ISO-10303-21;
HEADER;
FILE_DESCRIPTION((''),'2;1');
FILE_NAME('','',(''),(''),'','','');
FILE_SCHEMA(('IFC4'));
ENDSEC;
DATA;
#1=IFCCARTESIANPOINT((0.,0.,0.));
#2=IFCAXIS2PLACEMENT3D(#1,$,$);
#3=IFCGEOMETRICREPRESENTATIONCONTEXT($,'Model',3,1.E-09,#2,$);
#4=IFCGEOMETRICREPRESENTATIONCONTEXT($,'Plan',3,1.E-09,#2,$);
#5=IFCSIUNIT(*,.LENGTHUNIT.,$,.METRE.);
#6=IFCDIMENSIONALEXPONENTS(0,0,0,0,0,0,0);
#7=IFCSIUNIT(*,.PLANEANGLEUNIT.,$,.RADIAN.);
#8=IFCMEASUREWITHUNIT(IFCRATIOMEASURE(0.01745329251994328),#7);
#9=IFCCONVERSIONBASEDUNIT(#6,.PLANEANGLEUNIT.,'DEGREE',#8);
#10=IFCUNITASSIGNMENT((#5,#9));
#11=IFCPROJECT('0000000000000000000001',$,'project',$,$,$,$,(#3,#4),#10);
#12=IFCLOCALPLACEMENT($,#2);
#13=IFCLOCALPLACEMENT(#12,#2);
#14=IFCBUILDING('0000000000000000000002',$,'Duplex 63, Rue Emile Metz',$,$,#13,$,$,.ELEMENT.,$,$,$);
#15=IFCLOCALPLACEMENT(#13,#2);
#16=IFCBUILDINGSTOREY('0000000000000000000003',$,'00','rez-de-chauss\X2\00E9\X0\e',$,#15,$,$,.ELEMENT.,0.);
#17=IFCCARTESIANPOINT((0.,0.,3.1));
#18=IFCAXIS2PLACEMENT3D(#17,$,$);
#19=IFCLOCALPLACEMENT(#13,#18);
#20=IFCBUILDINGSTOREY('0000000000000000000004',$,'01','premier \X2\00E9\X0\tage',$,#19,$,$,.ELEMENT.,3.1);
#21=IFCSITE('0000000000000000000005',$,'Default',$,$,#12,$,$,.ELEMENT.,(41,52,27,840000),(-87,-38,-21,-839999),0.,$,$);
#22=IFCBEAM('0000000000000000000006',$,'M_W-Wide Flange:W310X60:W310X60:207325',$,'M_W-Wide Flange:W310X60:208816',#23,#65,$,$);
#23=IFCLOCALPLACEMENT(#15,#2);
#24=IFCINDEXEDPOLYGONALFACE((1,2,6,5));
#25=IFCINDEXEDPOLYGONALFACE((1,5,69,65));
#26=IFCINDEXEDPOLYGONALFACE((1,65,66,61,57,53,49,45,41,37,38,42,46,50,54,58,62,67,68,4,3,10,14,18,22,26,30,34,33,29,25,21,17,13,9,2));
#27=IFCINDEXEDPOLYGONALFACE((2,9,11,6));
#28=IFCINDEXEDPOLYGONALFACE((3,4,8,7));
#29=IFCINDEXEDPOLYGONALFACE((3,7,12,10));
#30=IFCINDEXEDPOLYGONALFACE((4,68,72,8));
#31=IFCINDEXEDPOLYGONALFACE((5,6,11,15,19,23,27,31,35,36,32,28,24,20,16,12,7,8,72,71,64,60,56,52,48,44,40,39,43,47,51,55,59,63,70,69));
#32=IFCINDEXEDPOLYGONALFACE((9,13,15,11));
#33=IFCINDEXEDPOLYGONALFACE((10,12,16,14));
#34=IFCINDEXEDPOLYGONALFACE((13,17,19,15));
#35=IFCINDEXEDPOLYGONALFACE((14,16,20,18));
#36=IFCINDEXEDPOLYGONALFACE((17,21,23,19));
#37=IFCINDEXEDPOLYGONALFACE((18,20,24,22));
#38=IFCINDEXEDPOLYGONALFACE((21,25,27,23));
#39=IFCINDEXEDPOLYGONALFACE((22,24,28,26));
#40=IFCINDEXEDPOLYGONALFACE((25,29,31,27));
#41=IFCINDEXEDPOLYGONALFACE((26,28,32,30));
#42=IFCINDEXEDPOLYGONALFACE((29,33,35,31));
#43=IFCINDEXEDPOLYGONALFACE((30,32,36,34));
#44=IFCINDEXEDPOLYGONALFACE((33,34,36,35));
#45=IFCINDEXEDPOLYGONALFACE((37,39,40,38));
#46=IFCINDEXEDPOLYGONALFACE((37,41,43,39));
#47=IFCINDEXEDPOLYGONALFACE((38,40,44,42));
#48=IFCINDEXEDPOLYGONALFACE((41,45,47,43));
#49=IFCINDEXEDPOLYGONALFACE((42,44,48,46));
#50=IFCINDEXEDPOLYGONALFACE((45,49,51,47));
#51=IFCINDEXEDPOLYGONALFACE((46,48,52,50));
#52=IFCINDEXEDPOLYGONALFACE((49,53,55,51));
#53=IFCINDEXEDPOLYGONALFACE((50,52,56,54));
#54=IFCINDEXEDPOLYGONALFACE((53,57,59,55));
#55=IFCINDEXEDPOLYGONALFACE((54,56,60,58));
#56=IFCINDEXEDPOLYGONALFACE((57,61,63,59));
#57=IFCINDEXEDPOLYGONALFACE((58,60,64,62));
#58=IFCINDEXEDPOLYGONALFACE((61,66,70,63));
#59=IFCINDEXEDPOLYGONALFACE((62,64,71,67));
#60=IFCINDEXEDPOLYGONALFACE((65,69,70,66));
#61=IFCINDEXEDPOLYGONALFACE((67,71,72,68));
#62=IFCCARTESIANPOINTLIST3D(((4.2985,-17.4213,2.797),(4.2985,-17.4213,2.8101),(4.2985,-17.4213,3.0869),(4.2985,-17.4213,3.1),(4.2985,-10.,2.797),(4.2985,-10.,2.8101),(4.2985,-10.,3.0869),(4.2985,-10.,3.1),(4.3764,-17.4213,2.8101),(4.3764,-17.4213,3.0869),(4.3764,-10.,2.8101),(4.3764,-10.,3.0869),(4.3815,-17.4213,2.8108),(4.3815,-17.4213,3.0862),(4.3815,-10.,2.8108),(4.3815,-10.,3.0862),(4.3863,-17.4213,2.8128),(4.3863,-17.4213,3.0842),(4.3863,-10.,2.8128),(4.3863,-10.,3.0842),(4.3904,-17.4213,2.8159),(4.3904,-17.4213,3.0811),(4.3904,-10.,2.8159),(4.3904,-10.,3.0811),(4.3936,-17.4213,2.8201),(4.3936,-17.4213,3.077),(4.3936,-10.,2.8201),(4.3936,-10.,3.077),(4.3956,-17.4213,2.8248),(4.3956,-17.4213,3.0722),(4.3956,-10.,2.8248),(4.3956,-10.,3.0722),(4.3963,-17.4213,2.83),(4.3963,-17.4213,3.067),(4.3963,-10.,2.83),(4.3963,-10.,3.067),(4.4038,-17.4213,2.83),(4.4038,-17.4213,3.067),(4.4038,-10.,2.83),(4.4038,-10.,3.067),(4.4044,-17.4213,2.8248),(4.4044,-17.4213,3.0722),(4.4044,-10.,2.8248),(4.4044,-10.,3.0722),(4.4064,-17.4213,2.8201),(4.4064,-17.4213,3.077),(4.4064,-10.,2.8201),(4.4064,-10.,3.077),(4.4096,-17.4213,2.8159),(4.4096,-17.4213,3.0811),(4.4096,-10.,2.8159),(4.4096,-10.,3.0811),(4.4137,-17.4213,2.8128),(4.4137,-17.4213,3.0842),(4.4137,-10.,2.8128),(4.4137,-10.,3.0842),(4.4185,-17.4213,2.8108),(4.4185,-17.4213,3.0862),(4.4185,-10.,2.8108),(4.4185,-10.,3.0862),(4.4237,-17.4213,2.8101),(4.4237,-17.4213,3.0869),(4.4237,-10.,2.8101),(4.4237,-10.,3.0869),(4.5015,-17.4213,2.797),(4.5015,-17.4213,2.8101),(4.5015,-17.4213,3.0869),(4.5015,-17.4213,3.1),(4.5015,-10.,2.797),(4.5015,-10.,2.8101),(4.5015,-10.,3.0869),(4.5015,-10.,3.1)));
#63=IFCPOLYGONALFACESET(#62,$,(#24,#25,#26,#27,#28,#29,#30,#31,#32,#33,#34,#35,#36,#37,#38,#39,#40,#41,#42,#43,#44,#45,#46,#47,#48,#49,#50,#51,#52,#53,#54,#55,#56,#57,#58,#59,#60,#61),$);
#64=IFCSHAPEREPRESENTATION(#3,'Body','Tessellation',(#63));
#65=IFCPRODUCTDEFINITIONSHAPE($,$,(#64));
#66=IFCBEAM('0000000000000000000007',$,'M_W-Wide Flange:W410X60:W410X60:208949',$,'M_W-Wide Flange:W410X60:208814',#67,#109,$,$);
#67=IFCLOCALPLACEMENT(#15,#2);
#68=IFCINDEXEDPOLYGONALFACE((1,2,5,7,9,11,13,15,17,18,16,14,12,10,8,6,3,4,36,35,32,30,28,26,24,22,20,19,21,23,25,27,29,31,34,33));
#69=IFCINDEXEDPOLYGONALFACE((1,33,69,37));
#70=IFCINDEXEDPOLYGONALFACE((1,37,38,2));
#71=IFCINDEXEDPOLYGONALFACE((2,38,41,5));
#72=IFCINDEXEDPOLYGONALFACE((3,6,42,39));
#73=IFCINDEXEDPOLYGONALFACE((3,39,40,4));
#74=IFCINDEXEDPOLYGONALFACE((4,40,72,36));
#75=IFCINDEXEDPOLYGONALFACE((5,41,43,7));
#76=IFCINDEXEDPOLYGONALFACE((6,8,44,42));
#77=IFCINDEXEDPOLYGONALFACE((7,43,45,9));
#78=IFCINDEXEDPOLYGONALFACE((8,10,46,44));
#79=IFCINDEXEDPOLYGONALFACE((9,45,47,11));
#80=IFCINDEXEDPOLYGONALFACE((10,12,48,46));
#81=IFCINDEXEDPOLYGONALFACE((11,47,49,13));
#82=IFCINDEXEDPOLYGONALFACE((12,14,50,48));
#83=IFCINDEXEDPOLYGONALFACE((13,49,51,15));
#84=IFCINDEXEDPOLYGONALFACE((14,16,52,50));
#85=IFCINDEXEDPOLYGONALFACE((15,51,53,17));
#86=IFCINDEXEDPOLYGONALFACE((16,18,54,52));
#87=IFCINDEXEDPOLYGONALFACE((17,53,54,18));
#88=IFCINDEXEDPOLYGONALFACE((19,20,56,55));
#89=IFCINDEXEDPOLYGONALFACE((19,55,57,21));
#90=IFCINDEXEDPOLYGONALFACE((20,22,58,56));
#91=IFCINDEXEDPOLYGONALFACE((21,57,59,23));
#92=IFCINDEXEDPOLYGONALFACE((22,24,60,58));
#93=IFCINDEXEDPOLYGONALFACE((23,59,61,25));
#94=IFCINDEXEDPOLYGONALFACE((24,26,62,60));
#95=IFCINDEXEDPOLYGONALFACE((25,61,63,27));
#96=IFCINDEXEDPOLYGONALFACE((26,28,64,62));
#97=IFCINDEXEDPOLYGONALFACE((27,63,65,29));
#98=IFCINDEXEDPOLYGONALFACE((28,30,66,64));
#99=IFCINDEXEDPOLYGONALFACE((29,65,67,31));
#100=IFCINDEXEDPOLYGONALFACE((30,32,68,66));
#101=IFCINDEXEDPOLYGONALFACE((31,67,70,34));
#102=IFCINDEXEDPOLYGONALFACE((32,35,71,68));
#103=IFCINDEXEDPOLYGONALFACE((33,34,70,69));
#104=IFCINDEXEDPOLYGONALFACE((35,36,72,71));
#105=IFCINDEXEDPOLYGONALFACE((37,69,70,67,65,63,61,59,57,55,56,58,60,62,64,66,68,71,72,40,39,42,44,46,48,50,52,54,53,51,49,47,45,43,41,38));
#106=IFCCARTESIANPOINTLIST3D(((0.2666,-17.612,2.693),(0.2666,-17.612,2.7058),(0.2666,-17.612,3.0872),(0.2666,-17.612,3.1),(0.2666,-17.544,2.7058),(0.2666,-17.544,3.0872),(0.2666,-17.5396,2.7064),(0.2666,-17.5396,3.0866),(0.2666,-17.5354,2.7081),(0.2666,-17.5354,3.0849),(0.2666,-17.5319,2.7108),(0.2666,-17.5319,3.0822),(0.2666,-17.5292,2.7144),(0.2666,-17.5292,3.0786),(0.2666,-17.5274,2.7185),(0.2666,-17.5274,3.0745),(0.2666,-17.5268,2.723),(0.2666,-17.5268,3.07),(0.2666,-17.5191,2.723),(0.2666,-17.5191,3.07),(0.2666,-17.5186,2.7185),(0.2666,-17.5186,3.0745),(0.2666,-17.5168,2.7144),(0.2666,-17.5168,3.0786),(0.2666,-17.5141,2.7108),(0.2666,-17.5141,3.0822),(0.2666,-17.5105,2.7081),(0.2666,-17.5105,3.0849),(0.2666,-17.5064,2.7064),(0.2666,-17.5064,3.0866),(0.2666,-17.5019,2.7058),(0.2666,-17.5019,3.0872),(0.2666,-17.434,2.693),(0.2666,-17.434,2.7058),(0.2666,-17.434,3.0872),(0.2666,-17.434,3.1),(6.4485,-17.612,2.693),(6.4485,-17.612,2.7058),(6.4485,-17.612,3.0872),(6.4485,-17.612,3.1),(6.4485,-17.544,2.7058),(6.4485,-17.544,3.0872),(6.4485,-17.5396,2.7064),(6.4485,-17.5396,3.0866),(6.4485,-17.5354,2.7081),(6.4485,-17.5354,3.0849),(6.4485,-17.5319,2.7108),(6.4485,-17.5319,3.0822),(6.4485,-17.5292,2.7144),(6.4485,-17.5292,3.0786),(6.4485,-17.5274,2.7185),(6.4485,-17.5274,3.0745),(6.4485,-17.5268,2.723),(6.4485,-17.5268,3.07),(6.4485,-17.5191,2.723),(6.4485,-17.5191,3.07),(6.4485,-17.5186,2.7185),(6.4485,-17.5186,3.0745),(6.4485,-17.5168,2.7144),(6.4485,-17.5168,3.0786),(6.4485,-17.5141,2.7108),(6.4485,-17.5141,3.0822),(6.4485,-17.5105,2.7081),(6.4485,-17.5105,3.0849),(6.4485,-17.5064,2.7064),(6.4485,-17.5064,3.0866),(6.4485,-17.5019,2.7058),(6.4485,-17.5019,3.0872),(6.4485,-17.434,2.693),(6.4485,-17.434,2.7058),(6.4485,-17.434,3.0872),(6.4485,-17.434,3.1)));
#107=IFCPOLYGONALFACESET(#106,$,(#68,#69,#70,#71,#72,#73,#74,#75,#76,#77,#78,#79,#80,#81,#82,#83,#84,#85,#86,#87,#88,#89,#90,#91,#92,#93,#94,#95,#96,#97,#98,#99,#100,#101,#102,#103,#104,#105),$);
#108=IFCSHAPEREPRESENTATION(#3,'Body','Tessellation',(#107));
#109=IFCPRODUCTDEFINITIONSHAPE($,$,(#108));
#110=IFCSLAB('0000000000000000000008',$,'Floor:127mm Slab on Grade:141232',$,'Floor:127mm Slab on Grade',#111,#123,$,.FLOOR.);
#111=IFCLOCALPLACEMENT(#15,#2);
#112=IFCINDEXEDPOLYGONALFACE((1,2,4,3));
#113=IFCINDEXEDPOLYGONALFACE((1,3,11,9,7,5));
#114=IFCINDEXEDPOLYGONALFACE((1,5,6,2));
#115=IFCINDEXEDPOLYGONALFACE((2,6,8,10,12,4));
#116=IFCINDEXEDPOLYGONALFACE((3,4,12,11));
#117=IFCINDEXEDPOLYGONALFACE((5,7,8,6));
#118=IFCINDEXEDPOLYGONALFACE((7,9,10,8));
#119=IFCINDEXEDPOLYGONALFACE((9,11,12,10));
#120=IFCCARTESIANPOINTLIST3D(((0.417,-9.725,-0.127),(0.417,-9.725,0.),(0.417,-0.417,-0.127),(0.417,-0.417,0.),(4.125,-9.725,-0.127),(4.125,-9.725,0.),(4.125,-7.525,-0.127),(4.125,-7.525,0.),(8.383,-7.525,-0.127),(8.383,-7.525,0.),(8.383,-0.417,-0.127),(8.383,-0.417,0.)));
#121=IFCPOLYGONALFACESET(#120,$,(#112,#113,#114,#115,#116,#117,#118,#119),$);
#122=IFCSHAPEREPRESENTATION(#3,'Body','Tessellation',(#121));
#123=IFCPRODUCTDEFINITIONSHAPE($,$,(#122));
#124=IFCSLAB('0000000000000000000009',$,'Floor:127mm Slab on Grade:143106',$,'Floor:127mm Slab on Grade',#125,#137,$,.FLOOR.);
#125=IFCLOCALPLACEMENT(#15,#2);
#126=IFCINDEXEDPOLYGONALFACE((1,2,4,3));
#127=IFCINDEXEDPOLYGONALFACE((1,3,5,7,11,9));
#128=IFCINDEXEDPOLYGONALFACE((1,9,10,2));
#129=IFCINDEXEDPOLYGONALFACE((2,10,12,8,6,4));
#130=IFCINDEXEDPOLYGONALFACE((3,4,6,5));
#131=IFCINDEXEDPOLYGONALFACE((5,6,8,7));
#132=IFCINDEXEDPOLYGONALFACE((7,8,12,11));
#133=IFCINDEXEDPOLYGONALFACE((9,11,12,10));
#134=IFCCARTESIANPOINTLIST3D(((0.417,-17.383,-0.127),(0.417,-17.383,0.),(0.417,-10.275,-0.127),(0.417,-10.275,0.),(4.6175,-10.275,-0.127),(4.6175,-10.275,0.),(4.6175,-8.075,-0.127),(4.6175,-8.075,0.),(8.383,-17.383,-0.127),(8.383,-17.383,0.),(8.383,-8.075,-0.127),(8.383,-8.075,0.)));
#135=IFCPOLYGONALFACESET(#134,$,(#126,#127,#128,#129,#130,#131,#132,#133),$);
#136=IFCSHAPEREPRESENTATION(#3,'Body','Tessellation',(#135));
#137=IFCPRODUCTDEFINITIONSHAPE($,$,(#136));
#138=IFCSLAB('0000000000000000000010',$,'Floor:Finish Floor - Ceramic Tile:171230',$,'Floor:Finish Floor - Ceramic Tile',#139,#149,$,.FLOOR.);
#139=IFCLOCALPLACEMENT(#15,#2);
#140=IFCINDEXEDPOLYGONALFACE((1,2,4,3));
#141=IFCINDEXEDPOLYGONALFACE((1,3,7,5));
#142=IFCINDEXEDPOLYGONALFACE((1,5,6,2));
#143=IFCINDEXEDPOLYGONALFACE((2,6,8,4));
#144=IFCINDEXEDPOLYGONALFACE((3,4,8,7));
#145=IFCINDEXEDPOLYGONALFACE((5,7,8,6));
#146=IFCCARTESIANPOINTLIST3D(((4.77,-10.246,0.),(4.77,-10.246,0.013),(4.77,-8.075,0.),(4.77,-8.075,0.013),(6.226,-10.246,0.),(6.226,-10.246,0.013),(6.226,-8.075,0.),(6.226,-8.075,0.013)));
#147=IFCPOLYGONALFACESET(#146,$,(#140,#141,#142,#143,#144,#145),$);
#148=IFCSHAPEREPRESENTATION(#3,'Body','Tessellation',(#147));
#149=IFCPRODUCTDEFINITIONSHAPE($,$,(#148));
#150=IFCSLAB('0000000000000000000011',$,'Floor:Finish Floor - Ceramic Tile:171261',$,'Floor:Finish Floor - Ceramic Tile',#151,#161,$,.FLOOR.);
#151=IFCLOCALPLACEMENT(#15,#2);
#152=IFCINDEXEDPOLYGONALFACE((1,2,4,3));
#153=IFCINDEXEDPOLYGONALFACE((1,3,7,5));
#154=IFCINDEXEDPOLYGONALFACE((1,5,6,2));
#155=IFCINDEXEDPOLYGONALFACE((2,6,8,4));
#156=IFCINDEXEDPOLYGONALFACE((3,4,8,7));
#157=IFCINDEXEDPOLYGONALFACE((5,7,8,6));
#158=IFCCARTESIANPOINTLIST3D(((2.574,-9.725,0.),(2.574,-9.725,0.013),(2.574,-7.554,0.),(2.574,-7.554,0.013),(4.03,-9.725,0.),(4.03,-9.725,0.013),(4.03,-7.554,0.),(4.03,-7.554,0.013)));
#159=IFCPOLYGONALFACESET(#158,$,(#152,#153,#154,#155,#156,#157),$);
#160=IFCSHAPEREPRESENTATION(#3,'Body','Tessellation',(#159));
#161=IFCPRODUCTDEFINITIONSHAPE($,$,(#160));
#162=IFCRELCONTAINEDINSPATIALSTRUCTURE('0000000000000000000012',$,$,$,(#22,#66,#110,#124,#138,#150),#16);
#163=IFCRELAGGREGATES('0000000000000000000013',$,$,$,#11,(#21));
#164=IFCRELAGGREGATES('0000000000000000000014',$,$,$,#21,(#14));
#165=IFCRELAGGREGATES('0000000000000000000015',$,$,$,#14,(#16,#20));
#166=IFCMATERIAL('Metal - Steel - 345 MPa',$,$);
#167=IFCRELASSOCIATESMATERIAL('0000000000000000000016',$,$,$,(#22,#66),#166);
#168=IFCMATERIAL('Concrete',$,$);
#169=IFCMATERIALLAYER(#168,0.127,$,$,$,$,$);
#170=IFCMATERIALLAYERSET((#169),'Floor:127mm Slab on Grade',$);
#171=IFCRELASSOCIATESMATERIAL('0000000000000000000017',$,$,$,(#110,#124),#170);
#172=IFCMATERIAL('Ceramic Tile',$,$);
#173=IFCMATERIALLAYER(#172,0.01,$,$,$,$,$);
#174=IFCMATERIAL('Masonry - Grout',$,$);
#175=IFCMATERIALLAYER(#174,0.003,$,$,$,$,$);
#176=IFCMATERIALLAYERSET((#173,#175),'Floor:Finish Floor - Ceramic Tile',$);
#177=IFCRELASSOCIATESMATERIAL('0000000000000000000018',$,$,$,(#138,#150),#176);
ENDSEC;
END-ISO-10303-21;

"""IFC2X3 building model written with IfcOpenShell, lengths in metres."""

from ifc_helpers import new_model, entity, si_unit, converted_unit, frame, frame_2d, origin, place, context, project, spatial, polyline, circle_curve, parameter, trimmed, segment, composite_curve, rectangle, outline, extrude, material, layer, layer_set, layer_usage, element, save


model = new_model("IFC2X3")

# Units and contexts
model_context = context("Model", 3, precision=1e-09, world=origin())
plan_context = context("Plan", 3, precision=1e-09, world=origin())
ifc_project = project(units=[si_unit("LENGTHUNIT", "METRE"), converted_unit("PLANEANGLEUNIT", "DEGREE", entity("IfcRatioMeasure", 0.01745329251994328), si_unit("PLANEANGLEUNIT", "RADIAN"), dimensions=[0, 0, 0, 0, 0, 0, 0])], contexts=[model_context, plan_context])

# Site, building, storey
site_placement = place(None, origin())
site = spatial("IfcSite", under=ifc_project, at=site_placement, Name="Default", CompositionType="ELEMENT", RefLatitude=(41, 52, 27, 840000), RefLongitude=(-87, -38, -21, -839999), RefElevation=0.0)
building_placement = place(site_placement, origin())
building = spatial("IfcBuilding", under=site, at=building_placement, Name="Duplex 63, Rue Emile Metz", CompositionType="ELEMENT")
storey_1_placement = place(building_placement, origin())
storey_1 = spatial("IfcBuildingStorey", under=building, at=storey_1_placement, Name="00", Description="rez-de-chaussée", CompositionType="ELEMENT", Elevation=0.0)

# Beams
ifc_material_1 = material(Name="Metal - Steel - 345 MPa")
beam_1_placement = place(storey_1_placement, frame((4.4, -10.0, 3.1), z_axis=(0.0, 0.0, 1.0), x_axis=(-1.0, 0.0, 0.0)))
element("IfcBeam", 1, at=beam_1_placement, inside=storey_1, material=ifc_material_1, Name="M_W-Wide Flange:W310X60:W310X60:207325", ObjectType="M_W-Wide Flange:W310X60:208816", context=model_context, shape_type="SweptSolid", body=[
    extrude(outline(composite_curve([segment(polyline([(0.1384, -0.1015), (0.1515, -0.1015)]), True, "CONTINUOUS"), segment(polyline([(0.1515, -0.1015), (0.1515, 0.1015)]), True, "CONTINUOUS"), segment(polyline([(0.1515, 0.1015), (0.1384, 0.1015)]), True, "CONTINUOUS"), segment(polyline([(0.1384, 0.1015), (0.1384, 0.0236)]), True, "CONTINUOUS"), segment(trimmed(circle_curve(frame_2d((0.1185, 0.0236), x_axis=(0.0, 1.0)), 0.0199), [parameter(180.0)], [parameter(270.0)], True, "PARAMETER"), False, "CONTINUOUS"), segment(polyline([(0.1185, 0.0037), (-0.1185, 0.0037)]), True, "CONTINUOUS"), segment(trimmed(circle_curve(frame_2d((-0.1185, 0.0236), x_axis=(0.0, 1.0)), 0.0199), [parameter(90.0)], [parameter(180.0)], True, "PARAMETER"), False, "CONTINUOUS"), segment(polyline([(-0.1384, 0.0236), (-0.1384, 0.1015)]), True, "CONTINUOUS"), segment(polyline([(-0.1384, 0.1015), (-0.1515, 0.1015)]), True, "CONTINUOUS"), segment(polyline([(-0.1515, 0.1015), (-0.1515, -0.1015)]), True, "CONTINUOUS"), segment(polyline([(-0.1515, -0.1015), (-0.1384, -0.1015)]), True, "CONTINUOUS"), segment(polyline([(-0.1384, -0.1015), (-0.1384, -0.0237)]), True, "CONTINUOUS"), segment(trimmed(circle_curve(frame_2d((-0.1185, -0.0237), x_axis=(0.0, 1.0)), 0.0199), [parameter(360.0)], [parameter(90.0)], True, "PARAMETER"), False, "CONTINUOUS"), segment(polyline([(-0.1185, -0.0038), (0.1185, -0.0038)]), True, "CONTINUOUS"), segment(trimmed(circle_curve(frame_2d((0.1185, -0.0237), x_axis=(0.0, 1.0)), 0.0199), [parameter(270.0)], [parameter(0.0)], True, "PARAMETER"), False, "CONTINUOUS"), segment(polyline([(0.1384, -0.0237), (0.1384, -0.1015)]), True, "CONTINUOUS")], self_intersect=False)), frame((0.0, 7.4213, -0.1515), z_axis=(0.0, -1.0, 0.0), x_axis=(0.0, 0.0, -1.0)), (0.0, 0.0, 1.0), 7.4213),
])
beam_2_placement = place(storey_1_placement, frame((0.2085, -17.523, 3.1), z_axis=(0.0, 0.0, 1.0), x_axis=(0.0, -1.0, 0.0)))
element("IfcBeam", 2, at=beam_2_placement, inside=storey_1, material=ifc_material_1, Name="M_W-Wide Flange:W410X60:W410X60:208949", ObjectType="M_W-Wide Flange:W410X60:208814", context=model_context, shape_type="SweptSolid", body=[
    extrude(outline(composite_curve([segment(polyline([(-0.089, -0.1907), (-0.089, -0.2035)]), True, "CONTINUOUS"), segment(polyline([(-0.089, -0.2035), (0.089, -0.2035)]), True, "CONTINUOUS"), segment(polyline([(0.089, -0.2035), (0.089, -0.1907)]), True, "CONTINUOUS"), segment(polyline([(0.089, -0.1907), (0.021, -0.1907)]), True, "CONTINUOUS"), segment(trimmed(circle_curve(frame_2d((0.021, -0.1735), x_axis=(0.0, -1.0)), 0.0172), [parameter(270.0)], [parameter(360.0)], True, "PARAMETER"), False, "CONTINUOUS"), segment(polyline([(0.0038, -0.1735), (0.0038, 0.1735)]), True, "CONTINUOUS"), segment(trimmed(circle_curve(frame_2d((0.021, 0.1735), x_axis=(-1.0, 0.0)), 0.0172), [parameter(270.0)], [parameter(360.0)], True, "PARAMETER"), False, "CONTINUOUS"), segment(polyline([(0.021, 0.1907), (0.089, 0.1907)]), True, "CONTINUOUS"), segment(polyline([(0.089, 0.1907), (0.089, 0.2035)]), True, "CONTINUOUS"), segment(polyline([(0.089, 0.2035), (-0.089, 0.2035)]), True, "CONTINUOUS"), segment(polyline([(-0.089, 0.2035), (-0.089, 0.1907)]), True, "CONTINUOUS"), segment(polyline([(-0.089, 0.1907), (-0.0211, 0.1907)]), True, "CONTINUOUS"), segment(trimmed(circle_curve(frame_2d((-0.0211, 0.1735), x_axis=(0.0, 1.0)), 0.0172), [parameter(270.0)], [parameter(0.0)], True, "PARAMETER"), False, "CONTINUOUS"), segment(polyline([(-0.0039, 0.1735), (-0.0039, -0.1735)]), True, "CONTINUOUS"), segment(trimmed(circle_curve(frame_2d((-0.0211, -0.1735), x_axis=(1.0, 0.0)), 0.0172), [parameter(270.0)], [parameter(0.0)], True, "PARAMETER"), False, "CONTINUOUS"), segment(polyline([(-0.0211, -0.1907), (-0.089, -0.1907)]), True, "CONTINUOUS")], self_intersect=False)), frame((0.0, 0.0581, -0.2035), z_axis=(0.0, -1.0, 0.0), x_axis=(1.0, 0.0, 0.0)), (0.0, 0.0, -1.0), 6.1819),
])

# Slabs
ifc_material_2 = material(Name="Concrete")
ifc_layer_1 = layer(ifc_material_2, 0.127)
ifc_layer_set_1 = layer_set([ifc_layer_1], Name="Floor:127mm Slab on Grade")
ifc_layer_usage_1 = layer_usage(ifc_layer_set_1, "AXIS3", "POSITIVE", 0.0)
slab_1_placement = place(storey_1_placement, frame((0.417, -9.725, -0.127)))
element("IfcSlab", 3, at=slab_1_placement, inside=storey_1, material=ifc_layer_usage_1, Name="Floor:127mm Slab on Grade:141232", ObjectType="Floor:127mm Slab on Grade", PredefinedType="FLOOR", context=model_context, shape_type="SweptSolid", body=[
    extrude(outline(polyline([(-3.983, 4.654), (-3.983, -2.454), (0.275, -2.454), (0.275, -4.654), (3.983, -4.654), (3.983, 4.654), (-3.983, 4.654)])), frame((3.983, 4.654, 0.127), z_axis=(0.0, 0.0, -1.0), x_axis=(-1.0, 0.0, 0.0)), (0.0, 0.0, 1.0), 0.127),
])
slab_2_placement = place(storey_1_placement, frame((0.417, -17.383, -0.127)))
element("IfcSlab", 4, at=slab_2_placement, inside=storey_1, material=ifc_layer_usage_1, Name="Floor:127mm Slab on Grade:143106", ObjectType="Floor:127mm Slab on Grade", PredefinedType="FLOOR", context=model_context, shape_type="SweptSolid", body=[
    extrude(outline(polyline([(-3.983, 4.654), (-3.983, -4.654), (3.983, -4.654), (3.983, 2.454), (-0.2175, 2.454), (-0.2175, 4.654), (-3.983, 4.654)])), frame((3.983, 4.654, 0.127), z_axis=(0.0, 0.0, -1.0), x_axis=(-1.0, 0.0, 0.0)), (0.0, 0.0, 1.0), 0.127),
])
ifc_material_3 = material(Name="Ceramic Tile")
ifc_layer_2 = layer(ifc_material_3, 0.01)
ifc_material_4 = material(Name="Masonry - Grout")
ifc_layer_3 = layer(ifc_material_4, 0.003)
ifc_layer_set_2 = layer_set([ifc_layer_2, ifc_layer_3], Name="Floor:Finish Floor - Ceramic Tile")
ifc_layer_usage_2 = layer_usage(ifc_layer_set_2, "AXIS3", "POSITIVE", 0.0)
slab_3_placement = place(storey_1_placement, frame((4.77, -10.246, 0.0)))
element("IfcSlab", 5, at=slab_3_placement, inside=storey_1, material=ifc_layer_usage_2, Name="Floor:Finish Floor - Ceramic Tile:171230", ObjectType="Floor:Finish Floor - Ceramic Tile", PredefinedType="FLOOR", context=model_context, shape_type="SweptSolid", body=[
    extrude(rectangle(XDim=1.456, YDim=2.171, at=frame_2d((0.0, 0.0), x_axis=(-1.0, 0.0))), frame((0.728, 1.0855, 0.013), z_axis=(0.0, 0.0, -1.0), x_axis=(-1.0, 0.0, 0.0)), (0.0, 0.0, 1.0), 0.013),
])
slab_4_placement = place(storey_1_placement, frame((2.574, -9.725, 0.0)))
element("IfcSlab", 6, at=slab_4_placement, inside=storey_1, material=ifc_layer_usage_2, Name="Floor:Finish Floor - Ceramic Tile:171261", ObjectType="Floor:Finish Floor - Ceramic Tile", PredefinedType="FLOOR", context=model_context, shape_type="SweptSolid", body=[
    extrude(rectangle(XDim=2.171, YDim=1.456, at=frame_2d((0.0, 0.0), x_axis=(0.0, -1.0))), frame((0.728, 1.0855, 0.013), z_axis=(0.0, 0.0, -1.0), x_axis=(-1.0, 0.0, 0.0)), (0.0, 0.0, 1.0), 0.013),
])

# Shared definitions
storey_2_placement = place(building_placement, frame((0.0, 0.0, 3.1)))
storey_2 = spatial("IfcBuildingStorey", under=building, at=storey_2_placement, Name="01", Description="premier étage", CompositionType="ELEMENT", Elevation=3.1)

save(model, "model.ifc")
